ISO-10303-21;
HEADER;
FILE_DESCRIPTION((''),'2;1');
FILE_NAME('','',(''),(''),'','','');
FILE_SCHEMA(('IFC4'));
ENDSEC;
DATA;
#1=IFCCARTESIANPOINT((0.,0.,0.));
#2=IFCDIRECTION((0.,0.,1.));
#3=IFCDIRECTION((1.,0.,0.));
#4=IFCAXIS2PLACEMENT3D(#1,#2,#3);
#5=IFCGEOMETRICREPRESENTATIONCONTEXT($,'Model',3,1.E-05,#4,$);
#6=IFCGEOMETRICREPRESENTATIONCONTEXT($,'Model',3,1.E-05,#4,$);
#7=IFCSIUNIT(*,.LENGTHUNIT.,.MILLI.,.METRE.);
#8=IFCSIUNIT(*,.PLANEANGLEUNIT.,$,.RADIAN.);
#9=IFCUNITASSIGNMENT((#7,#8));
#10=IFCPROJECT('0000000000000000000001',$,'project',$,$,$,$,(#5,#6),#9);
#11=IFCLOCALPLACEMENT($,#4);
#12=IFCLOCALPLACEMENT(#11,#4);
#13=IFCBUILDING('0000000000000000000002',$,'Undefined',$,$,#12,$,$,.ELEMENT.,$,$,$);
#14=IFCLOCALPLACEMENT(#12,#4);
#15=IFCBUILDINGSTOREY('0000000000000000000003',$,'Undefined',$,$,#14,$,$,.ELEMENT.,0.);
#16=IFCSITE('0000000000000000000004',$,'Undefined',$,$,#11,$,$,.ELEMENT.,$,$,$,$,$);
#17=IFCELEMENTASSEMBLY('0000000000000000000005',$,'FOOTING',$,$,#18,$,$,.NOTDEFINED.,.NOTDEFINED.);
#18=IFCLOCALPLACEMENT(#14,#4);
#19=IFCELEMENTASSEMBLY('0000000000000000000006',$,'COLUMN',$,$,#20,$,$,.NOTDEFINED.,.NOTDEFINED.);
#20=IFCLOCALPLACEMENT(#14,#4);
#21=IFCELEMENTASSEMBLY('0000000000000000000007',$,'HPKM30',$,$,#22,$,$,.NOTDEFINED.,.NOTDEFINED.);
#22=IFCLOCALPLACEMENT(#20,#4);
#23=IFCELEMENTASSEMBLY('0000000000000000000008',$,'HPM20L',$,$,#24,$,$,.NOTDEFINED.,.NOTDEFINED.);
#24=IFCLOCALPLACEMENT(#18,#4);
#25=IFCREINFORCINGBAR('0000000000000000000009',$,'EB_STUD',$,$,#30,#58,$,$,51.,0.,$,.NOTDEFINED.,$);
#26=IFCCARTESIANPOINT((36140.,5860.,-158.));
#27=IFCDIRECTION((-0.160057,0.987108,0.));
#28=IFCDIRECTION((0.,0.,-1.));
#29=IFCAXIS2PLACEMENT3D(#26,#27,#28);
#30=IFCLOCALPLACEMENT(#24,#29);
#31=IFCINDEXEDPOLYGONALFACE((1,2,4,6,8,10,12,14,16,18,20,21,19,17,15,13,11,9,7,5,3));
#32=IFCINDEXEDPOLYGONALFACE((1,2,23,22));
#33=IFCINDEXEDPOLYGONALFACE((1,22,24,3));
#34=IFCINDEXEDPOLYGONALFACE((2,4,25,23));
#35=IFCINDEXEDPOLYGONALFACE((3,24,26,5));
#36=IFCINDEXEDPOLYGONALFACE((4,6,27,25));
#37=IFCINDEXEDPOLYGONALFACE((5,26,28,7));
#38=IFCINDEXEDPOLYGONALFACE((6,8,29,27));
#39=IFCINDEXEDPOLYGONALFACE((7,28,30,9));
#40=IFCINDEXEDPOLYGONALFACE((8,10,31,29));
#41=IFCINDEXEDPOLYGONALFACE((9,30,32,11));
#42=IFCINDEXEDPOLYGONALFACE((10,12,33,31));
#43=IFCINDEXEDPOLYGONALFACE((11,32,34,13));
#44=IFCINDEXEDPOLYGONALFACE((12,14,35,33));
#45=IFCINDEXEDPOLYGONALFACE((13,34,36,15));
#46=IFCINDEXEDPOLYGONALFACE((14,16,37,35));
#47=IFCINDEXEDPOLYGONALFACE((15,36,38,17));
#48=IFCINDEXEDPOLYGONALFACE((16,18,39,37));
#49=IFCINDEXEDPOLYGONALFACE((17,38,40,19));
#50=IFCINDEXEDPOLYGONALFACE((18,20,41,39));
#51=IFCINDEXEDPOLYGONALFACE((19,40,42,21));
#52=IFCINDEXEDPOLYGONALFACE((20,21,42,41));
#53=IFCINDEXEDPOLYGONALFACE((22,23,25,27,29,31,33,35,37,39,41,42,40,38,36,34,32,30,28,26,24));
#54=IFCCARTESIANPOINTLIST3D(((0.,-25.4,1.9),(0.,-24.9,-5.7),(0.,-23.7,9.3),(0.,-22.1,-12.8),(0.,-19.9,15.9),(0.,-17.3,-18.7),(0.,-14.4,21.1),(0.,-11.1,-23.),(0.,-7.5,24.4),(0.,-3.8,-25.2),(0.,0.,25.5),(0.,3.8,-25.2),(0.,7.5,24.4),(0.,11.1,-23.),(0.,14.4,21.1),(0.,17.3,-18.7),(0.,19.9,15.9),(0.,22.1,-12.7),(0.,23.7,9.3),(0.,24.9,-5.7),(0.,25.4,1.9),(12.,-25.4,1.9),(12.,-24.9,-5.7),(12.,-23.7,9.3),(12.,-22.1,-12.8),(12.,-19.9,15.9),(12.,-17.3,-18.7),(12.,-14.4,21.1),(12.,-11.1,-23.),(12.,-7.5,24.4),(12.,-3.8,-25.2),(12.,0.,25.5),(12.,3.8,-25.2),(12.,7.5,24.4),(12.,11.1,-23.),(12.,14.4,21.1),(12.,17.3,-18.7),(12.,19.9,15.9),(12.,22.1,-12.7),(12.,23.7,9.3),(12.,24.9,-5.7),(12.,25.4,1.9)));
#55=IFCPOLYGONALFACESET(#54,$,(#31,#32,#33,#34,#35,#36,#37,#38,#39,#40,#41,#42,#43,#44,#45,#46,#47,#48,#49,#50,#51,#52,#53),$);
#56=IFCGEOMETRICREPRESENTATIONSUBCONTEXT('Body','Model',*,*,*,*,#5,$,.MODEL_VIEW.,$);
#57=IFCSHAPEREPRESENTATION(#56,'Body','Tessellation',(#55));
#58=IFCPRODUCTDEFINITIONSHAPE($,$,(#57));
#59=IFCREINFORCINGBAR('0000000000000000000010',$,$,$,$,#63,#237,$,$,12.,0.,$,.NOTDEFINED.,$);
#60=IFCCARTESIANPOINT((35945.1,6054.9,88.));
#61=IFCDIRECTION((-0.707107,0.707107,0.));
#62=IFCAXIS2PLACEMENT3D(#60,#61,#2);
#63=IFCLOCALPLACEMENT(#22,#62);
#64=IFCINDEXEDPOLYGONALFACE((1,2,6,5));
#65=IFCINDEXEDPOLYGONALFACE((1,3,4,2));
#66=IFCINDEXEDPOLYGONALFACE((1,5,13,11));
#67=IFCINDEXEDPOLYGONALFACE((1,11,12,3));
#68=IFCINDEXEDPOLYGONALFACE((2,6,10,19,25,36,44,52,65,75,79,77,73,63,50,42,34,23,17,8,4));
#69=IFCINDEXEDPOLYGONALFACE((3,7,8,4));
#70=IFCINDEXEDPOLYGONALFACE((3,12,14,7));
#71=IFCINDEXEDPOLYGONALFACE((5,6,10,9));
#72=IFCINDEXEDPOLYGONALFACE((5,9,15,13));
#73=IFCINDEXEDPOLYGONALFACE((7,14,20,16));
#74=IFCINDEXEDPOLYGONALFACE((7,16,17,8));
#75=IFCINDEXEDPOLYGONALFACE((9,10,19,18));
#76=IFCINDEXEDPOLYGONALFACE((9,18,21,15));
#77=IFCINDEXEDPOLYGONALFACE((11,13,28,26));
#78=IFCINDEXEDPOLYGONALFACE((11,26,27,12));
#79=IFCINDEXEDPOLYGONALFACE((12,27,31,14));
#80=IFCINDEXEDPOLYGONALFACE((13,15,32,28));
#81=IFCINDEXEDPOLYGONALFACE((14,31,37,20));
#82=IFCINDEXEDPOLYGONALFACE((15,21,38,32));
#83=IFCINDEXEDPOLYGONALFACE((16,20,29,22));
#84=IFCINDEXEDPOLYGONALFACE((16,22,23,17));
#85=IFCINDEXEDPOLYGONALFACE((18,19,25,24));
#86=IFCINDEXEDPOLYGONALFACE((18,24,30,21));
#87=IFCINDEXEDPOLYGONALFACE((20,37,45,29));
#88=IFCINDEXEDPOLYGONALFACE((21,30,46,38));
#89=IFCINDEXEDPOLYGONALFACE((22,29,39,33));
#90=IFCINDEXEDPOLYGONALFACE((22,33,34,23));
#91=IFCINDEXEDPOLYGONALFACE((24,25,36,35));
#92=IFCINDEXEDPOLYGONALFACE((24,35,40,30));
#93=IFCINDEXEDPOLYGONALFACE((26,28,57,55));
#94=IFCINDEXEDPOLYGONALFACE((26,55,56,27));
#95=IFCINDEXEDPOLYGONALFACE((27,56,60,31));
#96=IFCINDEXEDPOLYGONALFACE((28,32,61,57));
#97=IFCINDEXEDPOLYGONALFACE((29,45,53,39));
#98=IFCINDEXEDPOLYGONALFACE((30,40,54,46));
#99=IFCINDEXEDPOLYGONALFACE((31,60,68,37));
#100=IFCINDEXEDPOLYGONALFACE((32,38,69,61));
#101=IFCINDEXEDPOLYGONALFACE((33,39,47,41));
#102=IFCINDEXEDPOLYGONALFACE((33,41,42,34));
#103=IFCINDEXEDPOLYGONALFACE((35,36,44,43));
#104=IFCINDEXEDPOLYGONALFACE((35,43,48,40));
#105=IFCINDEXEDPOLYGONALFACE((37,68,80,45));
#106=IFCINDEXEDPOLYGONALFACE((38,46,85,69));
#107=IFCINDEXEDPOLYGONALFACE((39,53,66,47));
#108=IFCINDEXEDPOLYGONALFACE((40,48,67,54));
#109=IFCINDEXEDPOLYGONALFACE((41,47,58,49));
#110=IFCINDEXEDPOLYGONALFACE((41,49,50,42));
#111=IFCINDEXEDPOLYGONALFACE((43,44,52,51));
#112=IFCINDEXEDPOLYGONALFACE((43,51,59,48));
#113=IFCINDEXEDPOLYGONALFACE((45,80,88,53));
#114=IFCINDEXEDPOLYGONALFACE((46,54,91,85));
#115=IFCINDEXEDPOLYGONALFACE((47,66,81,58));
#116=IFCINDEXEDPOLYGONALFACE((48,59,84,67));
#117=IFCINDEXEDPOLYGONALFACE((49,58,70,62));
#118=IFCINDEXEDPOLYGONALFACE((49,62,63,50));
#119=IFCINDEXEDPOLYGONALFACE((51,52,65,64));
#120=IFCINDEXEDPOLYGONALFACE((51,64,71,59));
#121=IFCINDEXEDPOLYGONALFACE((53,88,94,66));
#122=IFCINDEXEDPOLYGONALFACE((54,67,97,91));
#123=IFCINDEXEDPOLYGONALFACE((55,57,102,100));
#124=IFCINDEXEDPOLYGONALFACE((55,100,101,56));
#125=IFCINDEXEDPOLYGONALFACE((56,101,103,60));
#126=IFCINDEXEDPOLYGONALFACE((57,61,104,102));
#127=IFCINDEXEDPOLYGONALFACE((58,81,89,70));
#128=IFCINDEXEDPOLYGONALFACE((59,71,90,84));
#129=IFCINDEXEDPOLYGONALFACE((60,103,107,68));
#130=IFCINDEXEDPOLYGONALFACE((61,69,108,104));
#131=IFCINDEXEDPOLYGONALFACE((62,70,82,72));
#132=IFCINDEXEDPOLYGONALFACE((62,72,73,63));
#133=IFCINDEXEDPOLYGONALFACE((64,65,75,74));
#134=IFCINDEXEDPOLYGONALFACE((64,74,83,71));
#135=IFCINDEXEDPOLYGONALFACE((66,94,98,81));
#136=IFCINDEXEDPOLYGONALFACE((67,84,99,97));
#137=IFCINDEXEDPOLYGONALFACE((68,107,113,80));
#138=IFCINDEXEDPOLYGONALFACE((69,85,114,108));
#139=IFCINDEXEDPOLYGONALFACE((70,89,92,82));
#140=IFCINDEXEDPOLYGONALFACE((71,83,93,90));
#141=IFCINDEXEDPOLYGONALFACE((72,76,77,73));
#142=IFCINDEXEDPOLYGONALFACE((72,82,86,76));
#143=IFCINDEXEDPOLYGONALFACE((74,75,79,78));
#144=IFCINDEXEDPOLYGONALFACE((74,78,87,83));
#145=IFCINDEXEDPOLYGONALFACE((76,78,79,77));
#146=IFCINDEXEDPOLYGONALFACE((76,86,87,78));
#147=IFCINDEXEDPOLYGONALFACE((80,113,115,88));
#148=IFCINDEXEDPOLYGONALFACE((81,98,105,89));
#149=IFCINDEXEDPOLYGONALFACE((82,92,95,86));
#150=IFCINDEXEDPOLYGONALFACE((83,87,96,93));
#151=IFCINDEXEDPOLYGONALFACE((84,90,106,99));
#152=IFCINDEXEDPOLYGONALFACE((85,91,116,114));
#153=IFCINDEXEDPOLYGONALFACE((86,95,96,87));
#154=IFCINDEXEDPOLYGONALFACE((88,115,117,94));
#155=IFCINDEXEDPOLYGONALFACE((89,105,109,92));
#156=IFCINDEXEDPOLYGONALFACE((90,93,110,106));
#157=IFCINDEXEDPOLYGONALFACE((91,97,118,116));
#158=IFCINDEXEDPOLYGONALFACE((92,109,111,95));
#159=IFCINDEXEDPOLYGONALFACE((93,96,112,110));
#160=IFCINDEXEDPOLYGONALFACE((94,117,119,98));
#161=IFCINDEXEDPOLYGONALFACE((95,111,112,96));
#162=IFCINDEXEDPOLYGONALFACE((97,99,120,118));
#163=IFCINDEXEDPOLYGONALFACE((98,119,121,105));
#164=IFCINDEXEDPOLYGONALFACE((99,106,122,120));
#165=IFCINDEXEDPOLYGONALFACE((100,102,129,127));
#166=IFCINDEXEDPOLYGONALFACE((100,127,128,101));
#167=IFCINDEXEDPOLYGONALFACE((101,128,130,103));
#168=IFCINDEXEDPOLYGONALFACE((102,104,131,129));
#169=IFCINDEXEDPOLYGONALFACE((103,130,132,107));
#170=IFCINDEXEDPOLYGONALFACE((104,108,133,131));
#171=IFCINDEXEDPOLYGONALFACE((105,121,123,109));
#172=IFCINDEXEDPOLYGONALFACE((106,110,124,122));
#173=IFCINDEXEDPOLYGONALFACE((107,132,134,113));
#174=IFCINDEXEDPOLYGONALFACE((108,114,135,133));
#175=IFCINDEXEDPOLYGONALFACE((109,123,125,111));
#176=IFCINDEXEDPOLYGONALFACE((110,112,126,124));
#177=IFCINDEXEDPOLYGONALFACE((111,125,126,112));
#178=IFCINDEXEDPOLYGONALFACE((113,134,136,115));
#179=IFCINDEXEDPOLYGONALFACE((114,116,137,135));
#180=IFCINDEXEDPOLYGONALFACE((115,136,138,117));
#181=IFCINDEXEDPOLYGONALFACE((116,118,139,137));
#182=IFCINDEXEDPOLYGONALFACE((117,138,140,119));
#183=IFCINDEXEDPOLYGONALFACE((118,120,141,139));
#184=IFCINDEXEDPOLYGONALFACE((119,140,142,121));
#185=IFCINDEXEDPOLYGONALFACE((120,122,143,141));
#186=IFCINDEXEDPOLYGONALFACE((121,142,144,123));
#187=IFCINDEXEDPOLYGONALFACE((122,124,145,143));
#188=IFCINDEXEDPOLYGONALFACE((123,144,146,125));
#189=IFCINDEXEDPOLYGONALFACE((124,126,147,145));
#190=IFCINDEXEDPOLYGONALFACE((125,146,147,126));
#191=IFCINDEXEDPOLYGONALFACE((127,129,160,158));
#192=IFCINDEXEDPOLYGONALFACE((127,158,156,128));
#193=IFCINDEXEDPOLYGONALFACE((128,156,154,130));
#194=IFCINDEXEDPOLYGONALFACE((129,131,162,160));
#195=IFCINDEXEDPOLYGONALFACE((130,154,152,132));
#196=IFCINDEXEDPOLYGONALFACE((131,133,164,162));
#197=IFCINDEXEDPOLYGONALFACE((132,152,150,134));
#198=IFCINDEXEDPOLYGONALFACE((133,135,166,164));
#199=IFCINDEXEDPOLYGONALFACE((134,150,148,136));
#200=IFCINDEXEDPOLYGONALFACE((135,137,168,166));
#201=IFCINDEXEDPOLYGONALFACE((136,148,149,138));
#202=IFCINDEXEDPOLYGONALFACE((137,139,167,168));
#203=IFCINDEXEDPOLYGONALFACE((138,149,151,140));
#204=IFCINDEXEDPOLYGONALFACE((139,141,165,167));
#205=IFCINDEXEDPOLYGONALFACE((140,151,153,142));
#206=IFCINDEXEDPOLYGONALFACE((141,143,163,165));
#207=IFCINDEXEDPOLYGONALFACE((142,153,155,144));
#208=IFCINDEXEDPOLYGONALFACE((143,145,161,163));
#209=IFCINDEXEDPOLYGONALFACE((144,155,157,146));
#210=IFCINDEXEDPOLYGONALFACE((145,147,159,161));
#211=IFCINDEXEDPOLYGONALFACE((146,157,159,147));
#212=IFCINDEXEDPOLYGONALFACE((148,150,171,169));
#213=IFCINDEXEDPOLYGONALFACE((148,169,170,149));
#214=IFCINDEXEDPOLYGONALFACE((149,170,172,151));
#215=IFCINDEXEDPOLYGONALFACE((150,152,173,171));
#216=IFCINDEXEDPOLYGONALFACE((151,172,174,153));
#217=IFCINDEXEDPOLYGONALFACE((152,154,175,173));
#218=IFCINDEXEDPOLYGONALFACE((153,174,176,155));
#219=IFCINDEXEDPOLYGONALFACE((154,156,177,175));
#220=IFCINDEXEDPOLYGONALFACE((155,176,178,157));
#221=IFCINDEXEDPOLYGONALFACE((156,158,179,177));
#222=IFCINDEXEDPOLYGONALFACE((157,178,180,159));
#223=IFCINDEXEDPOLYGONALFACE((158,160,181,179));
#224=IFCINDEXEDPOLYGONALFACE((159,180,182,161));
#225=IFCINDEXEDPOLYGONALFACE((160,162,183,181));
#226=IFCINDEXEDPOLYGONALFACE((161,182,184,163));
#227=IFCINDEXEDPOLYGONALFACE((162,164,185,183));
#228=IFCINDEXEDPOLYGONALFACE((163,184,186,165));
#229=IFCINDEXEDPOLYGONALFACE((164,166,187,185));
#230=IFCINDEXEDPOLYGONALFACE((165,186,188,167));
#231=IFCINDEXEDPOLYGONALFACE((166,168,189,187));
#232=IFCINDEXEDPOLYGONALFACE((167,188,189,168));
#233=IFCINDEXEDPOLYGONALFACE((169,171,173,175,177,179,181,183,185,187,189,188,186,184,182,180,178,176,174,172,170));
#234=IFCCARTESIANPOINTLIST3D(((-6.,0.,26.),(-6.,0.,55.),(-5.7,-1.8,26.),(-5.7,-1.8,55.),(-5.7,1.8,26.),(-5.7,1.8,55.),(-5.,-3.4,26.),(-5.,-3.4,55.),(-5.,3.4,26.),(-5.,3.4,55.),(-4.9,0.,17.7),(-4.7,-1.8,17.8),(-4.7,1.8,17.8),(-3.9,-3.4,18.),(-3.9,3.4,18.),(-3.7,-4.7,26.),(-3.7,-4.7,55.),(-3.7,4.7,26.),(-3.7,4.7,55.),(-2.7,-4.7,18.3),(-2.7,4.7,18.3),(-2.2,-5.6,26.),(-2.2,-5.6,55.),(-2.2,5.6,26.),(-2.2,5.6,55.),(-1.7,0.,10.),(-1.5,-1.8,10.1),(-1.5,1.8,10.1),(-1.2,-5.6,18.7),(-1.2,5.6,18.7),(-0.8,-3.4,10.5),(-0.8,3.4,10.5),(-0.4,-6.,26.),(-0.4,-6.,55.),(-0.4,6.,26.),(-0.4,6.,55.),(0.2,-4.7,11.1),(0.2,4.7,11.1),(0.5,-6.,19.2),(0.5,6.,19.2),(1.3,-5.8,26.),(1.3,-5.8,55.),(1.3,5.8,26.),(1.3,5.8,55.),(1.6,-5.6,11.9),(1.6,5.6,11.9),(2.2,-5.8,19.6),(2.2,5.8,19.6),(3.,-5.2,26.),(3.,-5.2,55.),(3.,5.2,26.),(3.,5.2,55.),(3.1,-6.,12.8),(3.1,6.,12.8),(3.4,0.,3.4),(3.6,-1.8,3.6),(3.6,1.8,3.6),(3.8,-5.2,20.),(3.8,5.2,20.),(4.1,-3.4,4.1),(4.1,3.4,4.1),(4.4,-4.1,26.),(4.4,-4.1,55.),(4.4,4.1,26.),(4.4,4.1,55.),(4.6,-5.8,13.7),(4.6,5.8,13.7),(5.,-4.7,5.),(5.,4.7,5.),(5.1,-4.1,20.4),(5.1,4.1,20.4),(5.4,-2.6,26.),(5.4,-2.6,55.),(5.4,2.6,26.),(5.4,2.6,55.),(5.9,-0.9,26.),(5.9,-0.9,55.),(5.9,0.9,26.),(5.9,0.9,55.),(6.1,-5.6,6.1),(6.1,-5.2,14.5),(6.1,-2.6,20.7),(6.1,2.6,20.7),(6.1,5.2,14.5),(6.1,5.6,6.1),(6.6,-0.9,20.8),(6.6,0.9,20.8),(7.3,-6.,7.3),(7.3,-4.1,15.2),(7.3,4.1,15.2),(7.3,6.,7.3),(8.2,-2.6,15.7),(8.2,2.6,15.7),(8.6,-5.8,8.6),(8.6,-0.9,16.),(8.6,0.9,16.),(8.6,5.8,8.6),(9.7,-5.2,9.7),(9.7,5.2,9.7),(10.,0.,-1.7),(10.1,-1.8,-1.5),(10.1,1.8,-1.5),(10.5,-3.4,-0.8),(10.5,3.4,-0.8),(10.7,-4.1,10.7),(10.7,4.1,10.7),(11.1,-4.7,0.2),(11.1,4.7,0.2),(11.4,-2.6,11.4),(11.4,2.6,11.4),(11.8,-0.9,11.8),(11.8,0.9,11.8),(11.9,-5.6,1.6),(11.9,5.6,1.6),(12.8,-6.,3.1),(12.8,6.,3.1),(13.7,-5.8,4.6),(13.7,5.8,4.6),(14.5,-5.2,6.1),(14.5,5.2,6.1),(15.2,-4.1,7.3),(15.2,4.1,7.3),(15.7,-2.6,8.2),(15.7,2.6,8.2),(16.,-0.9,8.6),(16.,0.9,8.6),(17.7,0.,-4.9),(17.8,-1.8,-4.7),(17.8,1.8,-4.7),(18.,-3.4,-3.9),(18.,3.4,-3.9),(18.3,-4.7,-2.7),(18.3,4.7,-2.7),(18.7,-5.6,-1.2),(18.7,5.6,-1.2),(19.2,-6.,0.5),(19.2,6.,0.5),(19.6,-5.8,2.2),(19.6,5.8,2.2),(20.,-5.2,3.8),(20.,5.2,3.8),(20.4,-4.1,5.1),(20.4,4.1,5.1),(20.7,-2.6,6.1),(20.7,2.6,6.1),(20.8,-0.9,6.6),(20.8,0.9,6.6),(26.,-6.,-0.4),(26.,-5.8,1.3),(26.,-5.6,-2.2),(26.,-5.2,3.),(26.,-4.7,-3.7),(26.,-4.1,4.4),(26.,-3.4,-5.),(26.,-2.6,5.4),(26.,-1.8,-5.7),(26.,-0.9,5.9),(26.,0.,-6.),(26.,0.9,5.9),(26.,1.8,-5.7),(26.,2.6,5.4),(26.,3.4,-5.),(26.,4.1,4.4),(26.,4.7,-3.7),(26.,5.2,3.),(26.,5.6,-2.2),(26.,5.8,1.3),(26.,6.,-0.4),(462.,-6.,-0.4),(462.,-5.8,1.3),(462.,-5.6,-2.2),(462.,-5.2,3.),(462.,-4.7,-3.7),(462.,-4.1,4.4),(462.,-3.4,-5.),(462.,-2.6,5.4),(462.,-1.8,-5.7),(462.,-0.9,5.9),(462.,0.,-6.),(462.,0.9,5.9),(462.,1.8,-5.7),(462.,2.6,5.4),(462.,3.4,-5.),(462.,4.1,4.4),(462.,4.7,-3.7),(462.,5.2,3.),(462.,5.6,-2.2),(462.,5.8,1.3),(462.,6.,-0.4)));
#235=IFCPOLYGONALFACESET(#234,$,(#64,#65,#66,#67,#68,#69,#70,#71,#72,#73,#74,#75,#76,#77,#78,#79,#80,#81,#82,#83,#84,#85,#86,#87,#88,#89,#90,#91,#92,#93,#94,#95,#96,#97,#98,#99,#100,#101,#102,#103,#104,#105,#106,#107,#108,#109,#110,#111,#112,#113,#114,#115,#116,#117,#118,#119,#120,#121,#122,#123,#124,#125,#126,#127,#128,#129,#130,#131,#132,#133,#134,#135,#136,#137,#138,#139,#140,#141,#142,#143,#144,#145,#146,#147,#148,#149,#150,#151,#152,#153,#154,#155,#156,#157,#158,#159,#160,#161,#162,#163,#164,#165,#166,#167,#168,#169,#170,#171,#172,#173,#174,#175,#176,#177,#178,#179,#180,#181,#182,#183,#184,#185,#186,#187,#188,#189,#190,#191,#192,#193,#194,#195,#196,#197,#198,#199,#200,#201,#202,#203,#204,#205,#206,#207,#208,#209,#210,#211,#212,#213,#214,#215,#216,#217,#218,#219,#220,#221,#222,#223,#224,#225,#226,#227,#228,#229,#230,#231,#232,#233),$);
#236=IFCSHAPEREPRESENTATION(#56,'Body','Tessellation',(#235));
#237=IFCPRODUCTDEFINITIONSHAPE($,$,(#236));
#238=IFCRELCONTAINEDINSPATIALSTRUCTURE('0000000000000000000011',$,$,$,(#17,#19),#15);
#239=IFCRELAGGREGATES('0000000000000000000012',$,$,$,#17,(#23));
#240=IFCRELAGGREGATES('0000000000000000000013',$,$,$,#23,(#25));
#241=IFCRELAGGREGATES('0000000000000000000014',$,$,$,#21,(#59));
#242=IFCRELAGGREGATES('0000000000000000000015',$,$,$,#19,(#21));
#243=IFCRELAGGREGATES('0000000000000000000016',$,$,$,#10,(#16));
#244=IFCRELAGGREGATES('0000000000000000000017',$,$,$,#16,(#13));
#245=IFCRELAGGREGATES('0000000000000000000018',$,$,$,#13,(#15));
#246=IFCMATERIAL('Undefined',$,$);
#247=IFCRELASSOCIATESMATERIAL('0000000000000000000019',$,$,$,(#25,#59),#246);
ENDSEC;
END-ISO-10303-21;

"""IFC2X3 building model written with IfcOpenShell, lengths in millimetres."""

from ifc_helpers import new_model, entity, si_unit, frame, origin_with_axes, place, context, subcontext, project, spatial, source, transform, mapped, material, element, aggregate, save


model = new_model("IFC2X3")

# Units and contexts
model_context_1 = context("Model", 3, precision=1e-05, world=origin_with_axes())
model_context_2 = context("Model", 3, precision=1e-05, world=origin_with_axes())
body_context = subcontext(model_context_1, "Body", "Model", "MODEL_VIEW")
ifc_project = project(units=[si_unit("LENGTHUNIT", "METRE", prefix="MILLI"), si_unit("PLANEANGLEUNIT", "RADIAN")], contexts=[model_context_1, model_context_2])

# Site, building, storey
site_placement = place(None, origin_with_axes())
site = spatial("IfcSite", under=ifc_project, at=site_placement, Name="Undefined", CompositionType="ELEMENT")
building_placement = place(site_placement, origin_with_axes())
building = spatial("IfcBuilding", under=site, at=building_placement, Name="Undefined", CompositionType="ELEMENT")
storey_placement = place(building_placement, origin_with_axes())
storey = spatial("IfcBuildingStorey", under=building, at=storey_placement, Name="Undefined", CompositionType="ELEMENT", Elevation=0.0)

# Element assembly
assembly_1_placement = place(storey_placement, origin_with_axes())
assembly_1 = element("IfcElementAssembly", 1, at=assembly_1_placement, inside=storey, Name="FOOTING", AssemblyPlace="NOTDEFINED", PredefinedType="NOTDEFINED")

# Element assembly
assembly_2_placement = place(storey_placement, origin_with_axes())
assembly_2 = element("IfcElementAssembly", 2, at=assembly_2_placement, inside=storey, Name="COLUMN", AssemblyPlace="NOTDEFINED", PredefinedType="NOTDEFINED")

# Element assembly
assembly_3_placement = place(assembly_2_placement, origin_with_axes())
assembly_3 = element("IfcElementAssembly", 3, at=assembly_3_placement, Name="HPKM30", AssemblyPlace="NOTDEFINED", PredefinedType="NOTDEFINED")

# Shared definitions
ifc_material_1 = material(Name="Undefined")

# Element assembly
assembly_4_placement = place(assembly_1_placement, origin_with_axes())
assembly_4 = element("IfcElementAssembly", 4, at=assembly_4_placement, Name="HPM20L", AssemblyPlace="NOTDEFINED", PredefinedType="NOTDEFINED")
aggregate(assembly_1, [assembly_4])

# Reinforcing bars
shared_shape_1 = source(origin_with_axes(), body_context, "Body", "AdvancedSweptSolid", [
    entity("IfcSweptDiskSolid", entity("IfcTrimmedCurve", entity("IfcLine", entity("IfcCartesianPoint", [0.0, 0.0, 0.0]), entity("IfcVector", entity("IfcDirection", [1.0, 0.0, 0.0]), 1.0)), [entity("IfcParameterValue", 0.0)], [entity("IfcParameterValue", 12.0)], True, "PARAMETER"), 25.5, None, 0.0, 12.0),
])
reinforcing_bar_1_placement = place(assembly_4_placement, frame((36140.0, 5860.0, -158.0), z_axis=(-0.160057, 0.987108, 0.0), x_axis=(0.0, 0.0, -1.0)))
reinforcing_bar_1 = element("IfcReinforcingBar", 5, at=reinforcing_bar_1_placement, material=ifc_material_1, Name="EB_STUD", BarRole="NOTDEFINED", CrossSectionArea=0.0, NominalDiameter=51.0, context=body_context, shape_type="MappedRepresentation", body=[
    mapped(shared_shape_1, transform((0.0, 0.0, 0.0))),
])
aggregate(assembly_4, [reinforcing_bar_1])
shared_shape_2 = source(origin_with_axes(), body_context, "Body", "AdvancedSweptSolid", [
    entity("IfcSweptDiskSolid", entity("IfcCompositeCurve", [entity("IfcCompositeCurveSegment", "CONTINUOUS", True, entity("IfcTrimmedCurve", entity("IfcLine", entity("IfcCartesianPoint", [0.0, 0.0, 0.0]), entity("IfcVector", entity("IfcDirection", [0.0, 0.0, -1.0]), 1.0)), [entity("IfcParameterValue", 0.0)], [entity("IfcParameterValue", 29.0)], True, "PARAMETER")), entity("IfcCompositeCurveSegment", "CONTINUOUS", True, entity("IfcTrimmedCurve", entity("IfcCircle", entity("IfcAxis2Placement3D", entity("IfcCartesianPoint", [26.0, 0.0, -29.0]), entity("IfcDirection", [0.0, -1.0, 0.0]), entity("IfcDirection", [-1.0, 0.0, 0.0])), 26.0), [entity("IfcParameterValue", 0.0)], [entity("IfcParameterValue", 1.570796)], True, "PARAMETER")), entity("IfcCompositeCurveSegment", "DISCONTINUOUS", True, entity("IfcTrimmedCurve", entity("IfcLine", entity("IfcCartesianPoint", [26.0, 0.0, -55.0]), entity("IfcVector", entity("IfcDirection", [1.0, 0.0, 0.0]), 1.0)), [entity("IfcParameterValue", 0.0)], [entity("IfcParameterValue", 436.0)], True, "PARAMETER"))], False), 6.0, None, 0.0, 466.6),
])
reinforcing_bar_2_placement = place(assembly_3_placement, frame((35945.1, 6054.9, 88.0), z_axis=(-0.707107, 0.707107, 0.0), x_axis=(0.0, 0.0, 1.0)))
reinforcing_bar_2 = element("IfcReinforcingBar", 6, at=reinforcing_bar_2_placement, material=ifc_material_1, BarRole="NOTDEFINED", CrossSectionArea=0.0, NominalDiameter=12.0, context=body_context, shape_type="MappedRepresentation", body=[
    mapped(shared_shape_2, transform((0.0, 0.0, 55.0))),
])
aggregate(assembly_3, [reinforcing_bar_2])
aggregate(assembly_2, [assembly_3])

save(model, "model.ifc")
